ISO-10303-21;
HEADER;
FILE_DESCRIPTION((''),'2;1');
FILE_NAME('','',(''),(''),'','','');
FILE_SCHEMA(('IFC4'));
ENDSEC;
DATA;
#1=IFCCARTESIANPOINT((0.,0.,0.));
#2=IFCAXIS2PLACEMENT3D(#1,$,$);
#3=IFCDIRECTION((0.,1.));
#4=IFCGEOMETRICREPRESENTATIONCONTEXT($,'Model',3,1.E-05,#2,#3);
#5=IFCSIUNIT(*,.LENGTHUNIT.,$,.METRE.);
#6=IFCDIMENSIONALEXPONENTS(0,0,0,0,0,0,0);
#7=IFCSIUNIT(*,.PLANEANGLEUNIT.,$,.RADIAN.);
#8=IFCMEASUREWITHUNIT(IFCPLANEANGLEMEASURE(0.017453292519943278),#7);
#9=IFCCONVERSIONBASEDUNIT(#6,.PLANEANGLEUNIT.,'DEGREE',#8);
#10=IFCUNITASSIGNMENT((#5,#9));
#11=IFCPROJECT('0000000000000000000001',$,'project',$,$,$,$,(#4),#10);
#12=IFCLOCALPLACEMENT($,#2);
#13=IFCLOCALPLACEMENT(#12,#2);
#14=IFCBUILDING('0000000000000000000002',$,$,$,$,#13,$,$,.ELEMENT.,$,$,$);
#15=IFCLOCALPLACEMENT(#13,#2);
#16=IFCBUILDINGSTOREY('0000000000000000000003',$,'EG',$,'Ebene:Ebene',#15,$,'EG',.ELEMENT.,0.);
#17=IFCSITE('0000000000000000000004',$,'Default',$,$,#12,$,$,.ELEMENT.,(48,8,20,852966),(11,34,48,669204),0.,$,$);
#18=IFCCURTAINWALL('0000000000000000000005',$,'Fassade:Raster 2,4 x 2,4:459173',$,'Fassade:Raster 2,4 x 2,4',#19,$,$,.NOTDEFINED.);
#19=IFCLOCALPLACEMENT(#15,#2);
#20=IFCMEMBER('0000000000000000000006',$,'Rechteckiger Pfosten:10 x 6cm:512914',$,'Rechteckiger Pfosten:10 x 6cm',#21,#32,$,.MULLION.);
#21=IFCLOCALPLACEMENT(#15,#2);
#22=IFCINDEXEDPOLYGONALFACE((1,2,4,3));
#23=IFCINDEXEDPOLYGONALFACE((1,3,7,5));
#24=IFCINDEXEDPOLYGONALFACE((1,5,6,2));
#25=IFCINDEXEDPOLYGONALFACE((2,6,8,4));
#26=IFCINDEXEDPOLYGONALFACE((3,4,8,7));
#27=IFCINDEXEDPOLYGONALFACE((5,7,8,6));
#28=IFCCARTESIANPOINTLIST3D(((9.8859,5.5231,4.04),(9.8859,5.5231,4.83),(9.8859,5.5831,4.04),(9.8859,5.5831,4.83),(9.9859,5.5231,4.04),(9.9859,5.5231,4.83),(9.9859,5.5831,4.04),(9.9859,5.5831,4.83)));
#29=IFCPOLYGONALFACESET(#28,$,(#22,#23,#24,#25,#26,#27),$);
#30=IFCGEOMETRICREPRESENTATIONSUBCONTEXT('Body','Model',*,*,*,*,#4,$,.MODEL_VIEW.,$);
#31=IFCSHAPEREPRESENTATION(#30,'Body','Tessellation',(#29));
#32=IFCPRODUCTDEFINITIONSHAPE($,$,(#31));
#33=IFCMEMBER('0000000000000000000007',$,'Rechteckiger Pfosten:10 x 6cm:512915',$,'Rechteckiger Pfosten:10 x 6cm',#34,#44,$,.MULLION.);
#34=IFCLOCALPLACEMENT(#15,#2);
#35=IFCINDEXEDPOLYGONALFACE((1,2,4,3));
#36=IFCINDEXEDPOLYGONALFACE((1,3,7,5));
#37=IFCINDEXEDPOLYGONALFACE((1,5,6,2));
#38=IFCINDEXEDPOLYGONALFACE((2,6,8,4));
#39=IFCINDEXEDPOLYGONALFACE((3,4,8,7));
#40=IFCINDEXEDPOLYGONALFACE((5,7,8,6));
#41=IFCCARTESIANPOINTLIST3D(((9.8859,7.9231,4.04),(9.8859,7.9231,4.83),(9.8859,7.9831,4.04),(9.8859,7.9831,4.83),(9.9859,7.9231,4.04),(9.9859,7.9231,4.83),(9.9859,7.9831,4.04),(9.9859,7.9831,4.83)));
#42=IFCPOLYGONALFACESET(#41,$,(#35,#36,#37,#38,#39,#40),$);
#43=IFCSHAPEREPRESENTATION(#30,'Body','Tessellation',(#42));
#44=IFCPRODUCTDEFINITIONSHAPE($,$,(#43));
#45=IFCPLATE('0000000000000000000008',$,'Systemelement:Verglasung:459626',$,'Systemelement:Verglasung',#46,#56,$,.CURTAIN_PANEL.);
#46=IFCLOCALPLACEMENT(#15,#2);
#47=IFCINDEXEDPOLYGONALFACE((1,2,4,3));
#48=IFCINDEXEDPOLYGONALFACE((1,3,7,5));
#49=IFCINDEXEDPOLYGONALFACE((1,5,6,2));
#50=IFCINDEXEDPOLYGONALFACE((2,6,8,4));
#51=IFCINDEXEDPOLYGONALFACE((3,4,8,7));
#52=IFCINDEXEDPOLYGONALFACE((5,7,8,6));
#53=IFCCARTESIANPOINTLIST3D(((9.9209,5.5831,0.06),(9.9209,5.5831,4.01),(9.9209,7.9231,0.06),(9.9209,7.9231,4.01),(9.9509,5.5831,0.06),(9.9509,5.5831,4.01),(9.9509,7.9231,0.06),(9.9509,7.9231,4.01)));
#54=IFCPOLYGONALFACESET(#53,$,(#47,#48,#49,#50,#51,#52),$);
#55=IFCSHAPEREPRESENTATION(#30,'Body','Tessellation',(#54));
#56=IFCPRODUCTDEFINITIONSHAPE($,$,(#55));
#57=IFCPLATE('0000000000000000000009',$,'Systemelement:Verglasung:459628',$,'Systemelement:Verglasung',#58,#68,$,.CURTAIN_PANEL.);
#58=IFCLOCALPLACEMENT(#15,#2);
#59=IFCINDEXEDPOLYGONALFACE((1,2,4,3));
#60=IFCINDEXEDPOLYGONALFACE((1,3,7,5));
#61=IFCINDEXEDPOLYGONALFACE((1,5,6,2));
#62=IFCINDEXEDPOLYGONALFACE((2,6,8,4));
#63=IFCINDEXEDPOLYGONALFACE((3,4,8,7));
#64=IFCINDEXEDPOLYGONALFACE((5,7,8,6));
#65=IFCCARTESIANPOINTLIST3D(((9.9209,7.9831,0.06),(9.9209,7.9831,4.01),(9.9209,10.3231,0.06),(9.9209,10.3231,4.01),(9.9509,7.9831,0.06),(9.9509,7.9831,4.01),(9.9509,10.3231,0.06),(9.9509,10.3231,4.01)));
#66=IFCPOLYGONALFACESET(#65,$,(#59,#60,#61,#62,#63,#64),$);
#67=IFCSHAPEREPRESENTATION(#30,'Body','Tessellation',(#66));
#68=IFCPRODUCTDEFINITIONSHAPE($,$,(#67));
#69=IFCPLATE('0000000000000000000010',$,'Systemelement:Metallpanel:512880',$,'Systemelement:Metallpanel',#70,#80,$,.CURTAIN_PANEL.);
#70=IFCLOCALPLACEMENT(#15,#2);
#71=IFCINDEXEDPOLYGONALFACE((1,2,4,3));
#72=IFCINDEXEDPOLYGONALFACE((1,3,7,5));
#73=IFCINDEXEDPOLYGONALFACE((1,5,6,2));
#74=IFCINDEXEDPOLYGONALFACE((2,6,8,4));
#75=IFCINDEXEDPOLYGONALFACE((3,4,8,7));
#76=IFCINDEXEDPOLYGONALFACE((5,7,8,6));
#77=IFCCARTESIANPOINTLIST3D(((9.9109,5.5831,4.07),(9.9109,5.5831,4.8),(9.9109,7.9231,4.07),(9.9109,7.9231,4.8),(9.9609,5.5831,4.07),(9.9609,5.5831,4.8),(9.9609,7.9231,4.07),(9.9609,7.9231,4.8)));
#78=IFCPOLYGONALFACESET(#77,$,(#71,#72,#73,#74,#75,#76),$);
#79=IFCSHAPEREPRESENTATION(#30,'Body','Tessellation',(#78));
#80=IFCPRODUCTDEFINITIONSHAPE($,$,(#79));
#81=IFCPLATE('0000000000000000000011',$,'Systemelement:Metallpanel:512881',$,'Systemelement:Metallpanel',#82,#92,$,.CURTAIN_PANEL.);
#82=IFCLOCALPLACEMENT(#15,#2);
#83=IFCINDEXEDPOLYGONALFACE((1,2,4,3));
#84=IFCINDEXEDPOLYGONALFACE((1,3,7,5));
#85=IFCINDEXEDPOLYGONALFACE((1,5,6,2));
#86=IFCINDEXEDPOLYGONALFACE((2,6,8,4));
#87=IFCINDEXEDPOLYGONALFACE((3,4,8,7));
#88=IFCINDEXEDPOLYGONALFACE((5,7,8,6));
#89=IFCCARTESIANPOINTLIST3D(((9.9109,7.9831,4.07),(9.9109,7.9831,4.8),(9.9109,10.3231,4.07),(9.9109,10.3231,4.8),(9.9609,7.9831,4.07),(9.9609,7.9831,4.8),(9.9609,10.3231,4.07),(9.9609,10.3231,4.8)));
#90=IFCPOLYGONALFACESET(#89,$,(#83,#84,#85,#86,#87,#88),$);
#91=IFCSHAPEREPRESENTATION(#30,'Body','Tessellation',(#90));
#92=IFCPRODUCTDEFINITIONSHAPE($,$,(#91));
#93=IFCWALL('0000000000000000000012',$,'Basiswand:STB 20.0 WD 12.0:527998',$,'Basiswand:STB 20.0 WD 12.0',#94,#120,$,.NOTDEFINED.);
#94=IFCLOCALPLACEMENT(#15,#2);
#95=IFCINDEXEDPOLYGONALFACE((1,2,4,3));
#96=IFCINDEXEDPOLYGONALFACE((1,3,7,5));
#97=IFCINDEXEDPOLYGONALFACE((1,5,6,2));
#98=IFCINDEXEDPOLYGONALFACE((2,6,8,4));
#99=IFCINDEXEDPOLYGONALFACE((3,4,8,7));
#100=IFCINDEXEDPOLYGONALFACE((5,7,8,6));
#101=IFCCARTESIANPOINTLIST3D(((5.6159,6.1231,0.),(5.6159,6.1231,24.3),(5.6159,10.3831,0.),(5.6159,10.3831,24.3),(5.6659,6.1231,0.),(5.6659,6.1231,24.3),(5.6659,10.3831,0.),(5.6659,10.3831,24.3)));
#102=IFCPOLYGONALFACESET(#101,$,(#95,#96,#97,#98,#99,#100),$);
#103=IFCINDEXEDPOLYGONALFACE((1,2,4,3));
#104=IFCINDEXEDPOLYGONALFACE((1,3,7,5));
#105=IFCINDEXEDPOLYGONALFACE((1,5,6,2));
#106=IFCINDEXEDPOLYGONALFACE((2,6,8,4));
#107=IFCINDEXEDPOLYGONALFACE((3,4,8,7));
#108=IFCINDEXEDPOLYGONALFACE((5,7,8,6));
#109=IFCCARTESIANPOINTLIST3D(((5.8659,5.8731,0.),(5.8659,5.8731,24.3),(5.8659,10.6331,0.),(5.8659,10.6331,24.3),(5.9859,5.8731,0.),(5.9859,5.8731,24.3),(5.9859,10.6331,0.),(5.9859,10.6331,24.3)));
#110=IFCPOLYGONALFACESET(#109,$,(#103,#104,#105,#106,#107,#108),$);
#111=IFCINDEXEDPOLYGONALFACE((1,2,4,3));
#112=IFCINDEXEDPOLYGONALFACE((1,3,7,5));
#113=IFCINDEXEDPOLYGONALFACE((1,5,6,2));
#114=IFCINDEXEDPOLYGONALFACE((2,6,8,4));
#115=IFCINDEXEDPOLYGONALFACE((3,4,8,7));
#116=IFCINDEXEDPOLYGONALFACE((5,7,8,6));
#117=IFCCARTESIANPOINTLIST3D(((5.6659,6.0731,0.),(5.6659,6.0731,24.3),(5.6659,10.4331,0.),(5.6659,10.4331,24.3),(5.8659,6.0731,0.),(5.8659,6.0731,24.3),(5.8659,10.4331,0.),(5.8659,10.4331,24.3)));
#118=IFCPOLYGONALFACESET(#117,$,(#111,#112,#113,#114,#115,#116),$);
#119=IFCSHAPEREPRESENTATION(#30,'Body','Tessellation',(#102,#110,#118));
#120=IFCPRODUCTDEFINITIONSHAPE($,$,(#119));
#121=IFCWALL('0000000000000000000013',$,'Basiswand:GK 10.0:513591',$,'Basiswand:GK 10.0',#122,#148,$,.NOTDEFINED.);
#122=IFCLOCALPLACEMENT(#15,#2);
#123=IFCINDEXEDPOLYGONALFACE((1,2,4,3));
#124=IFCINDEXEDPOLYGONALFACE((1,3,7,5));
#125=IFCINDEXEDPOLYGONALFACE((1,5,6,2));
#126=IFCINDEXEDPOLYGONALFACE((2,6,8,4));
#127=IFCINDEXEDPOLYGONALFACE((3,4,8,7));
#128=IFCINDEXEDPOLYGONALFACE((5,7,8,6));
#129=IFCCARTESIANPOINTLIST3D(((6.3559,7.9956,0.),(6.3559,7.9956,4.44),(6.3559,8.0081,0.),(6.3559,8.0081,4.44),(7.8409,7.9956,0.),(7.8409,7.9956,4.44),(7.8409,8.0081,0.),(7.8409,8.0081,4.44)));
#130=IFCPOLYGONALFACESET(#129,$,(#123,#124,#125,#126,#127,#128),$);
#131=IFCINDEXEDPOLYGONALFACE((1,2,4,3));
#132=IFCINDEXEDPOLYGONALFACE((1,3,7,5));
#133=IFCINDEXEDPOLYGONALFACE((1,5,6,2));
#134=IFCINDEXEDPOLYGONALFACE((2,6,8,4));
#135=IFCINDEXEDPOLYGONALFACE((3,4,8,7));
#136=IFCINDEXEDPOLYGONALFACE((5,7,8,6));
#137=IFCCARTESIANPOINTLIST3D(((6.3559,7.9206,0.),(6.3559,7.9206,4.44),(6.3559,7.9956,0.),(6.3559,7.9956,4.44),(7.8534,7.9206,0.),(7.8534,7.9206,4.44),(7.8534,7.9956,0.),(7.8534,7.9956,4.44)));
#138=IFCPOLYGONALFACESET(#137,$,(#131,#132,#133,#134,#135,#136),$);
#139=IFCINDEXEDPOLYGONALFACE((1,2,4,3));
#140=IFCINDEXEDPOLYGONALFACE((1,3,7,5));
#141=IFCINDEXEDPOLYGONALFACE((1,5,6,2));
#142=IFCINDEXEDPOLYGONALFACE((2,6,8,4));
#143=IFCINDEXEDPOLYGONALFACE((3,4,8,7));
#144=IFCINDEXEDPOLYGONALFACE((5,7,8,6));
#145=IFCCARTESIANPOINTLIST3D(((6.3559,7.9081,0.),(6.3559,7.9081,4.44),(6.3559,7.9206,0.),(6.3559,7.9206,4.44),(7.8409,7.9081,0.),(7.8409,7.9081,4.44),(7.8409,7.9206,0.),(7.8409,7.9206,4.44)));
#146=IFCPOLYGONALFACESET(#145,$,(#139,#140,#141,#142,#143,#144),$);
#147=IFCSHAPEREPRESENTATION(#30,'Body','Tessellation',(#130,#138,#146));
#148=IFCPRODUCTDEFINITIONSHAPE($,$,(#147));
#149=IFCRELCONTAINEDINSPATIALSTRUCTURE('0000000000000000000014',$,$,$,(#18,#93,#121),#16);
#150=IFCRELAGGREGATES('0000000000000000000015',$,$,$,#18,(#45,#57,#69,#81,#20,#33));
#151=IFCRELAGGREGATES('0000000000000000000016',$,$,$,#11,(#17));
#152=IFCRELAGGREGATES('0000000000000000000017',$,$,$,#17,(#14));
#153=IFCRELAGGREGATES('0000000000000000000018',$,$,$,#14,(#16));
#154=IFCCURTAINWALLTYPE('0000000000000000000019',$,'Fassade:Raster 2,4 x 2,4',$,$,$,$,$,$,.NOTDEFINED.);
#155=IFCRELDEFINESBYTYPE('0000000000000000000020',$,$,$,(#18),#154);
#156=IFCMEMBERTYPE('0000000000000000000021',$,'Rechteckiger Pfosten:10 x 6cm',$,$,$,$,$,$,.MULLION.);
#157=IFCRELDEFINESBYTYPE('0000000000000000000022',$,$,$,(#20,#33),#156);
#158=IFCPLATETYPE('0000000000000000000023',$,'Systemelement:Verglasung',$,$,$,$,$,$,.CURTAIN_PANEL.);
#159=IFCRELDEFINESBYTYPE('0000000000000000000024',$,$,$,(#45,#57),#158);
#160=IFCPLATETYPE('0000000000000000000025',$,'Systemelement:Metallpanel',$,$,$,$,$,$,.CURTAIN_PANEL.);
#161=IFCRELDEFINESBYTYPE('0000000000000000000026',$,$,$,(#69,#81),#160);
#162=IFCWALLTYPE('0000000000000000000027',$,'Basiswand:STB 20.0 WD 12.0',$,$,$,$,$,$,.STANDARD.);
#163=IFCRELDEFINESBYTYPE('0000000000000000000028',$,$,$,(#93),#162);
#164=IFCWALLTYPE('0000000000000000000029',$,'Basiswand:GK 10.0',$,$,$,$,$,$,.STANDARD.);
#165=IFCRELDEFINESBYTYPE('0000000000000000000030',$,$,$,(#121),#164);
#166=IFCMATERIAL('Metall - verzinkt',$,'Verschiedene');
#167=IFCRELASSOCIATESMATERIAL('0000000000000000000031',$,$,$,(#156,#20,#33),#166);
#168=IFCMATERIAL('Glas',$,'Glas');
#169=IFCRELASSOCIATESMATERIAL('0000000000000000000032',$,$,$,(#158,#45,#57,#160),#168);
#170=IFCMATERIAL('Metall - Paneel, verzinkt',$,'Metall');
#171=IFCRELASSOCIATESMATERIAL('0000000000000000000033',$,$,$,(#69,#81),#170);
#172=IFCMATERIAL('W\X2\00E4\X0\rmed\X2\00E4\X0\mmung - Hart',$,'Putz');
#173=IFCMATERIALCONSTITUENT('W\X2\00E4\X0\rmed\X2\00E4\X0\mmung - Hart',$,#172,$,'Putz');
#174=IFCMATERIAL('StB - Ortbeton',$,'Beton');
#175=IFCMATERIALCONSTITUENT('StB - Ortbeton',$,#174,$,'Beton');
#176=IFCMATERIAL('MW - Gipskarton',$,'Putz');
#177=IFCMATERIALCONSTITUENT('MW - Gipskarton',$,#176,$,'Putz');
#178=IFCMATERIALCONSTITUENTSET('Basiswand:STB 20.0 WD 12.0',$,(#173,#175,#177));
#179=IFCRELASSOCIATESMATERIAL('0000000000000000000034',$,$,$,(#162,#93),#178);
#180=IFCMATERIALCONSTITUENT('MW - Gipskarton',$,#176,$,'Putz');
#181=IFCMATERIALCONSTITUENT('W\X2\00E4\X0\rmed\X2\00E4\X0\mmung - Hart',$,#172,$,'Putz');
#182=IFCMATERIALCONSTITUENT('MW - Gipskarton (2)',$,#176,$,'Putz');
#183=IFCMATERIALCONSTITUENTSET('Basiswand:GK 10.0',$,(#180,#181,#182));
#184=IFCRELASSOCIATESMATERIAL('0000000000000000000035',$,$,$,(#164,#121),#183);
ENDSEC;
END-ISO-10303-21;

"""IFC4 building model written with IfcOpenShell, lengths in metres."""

from ifc_helpers import new_model, entity, si_unit, converted_unit, direction, frame, origin, place, context, subcontext, project, spatial, indexed_curve, outline, extrude, source, transform, mapped, material, constituent, constituent_set, type_object, type_shapes, element, aggregate, save


model = new_model("IFC4")

# Units and contexts
model_context = context("Model", 3, precision=1e-05, world=origin(), true_north=direction((0.0, 1.0)))
body_context = subcontext(model_context, "Body", "Model", "MODEL_VIEW")
ifc_project = project(units=[si_unit("LENGTHUNIT", "METRE"), converted_unit("PLANEANGLEUNIT", "DEGREE", entity("IfcPlaneAngleMeasure", 0.017453292519943278), si_unit("PLANEANGLEUNIT", "RADIAN"), dimensions=[0, 0, 0, 0, 0, 0, 0])], contexts=[model_context])

# Site, building, storey
site_placement = place(None, origin())
site = spatial("IfcSite", under=ifc_project, at=site_placement, Name="Default", CompositionType="ELEMENT", RefLatitude=(48, 8, 20, 852966), RefLongitude=(11, 34, 48, 669204), RefElevation=0.0)
building_placement = place(site_placement, origin())
building = spatial("IfcBuilding", under=site, at=building_placement, CompositionType="ELEMENT")
storey_placement = place(building_placement, origin())
storey = spatial("IfcBuildingStorey", under=building, at=storey_placement, Name="EG", ObjectType="Ebene:Ebene", LongName="EG", CompositionType="ELEMENT", Elevation=0.0)

# Curtain wall, members, plates
curtain_wall_type = type_object("IfcCurtainWallType", Name="Fassade:Raster 2,4 x 2,4", PredefinedType="NOTDEFINED")
curtain_wall_placement = place(storey_placement, origin())
curtain_wall = element("IfcCurtainWall", 1, at=curtain_wall_placement, inside=storey, type_object=curtain_wall_type, Name="Fassade:Raster 2,4 x 2,4:459173", ObjectType="Fassade:Raster 2,4 x 2,4", PredefinedType="NOTDEFINED")
ifc_material_1 = material(Name="Metall - verzinkt", Category="Verschiedene")
member_type_1 = type_object("IfcMemberType", Name="Rechteckiger Pfosten:10 x 6cm", PredefinedType="MULLION", material=ifc_material_1)
shared_shape_1 = source(origin(), body_context, "Body", "SweptSolid", [
    extrude(outline(indexed_curve([(-0.03, -0.05), (0.03, -0.05), (0.03, 0.05), (-0.03, 0.05), (-0.03, -0.05)], self_intersect=False)), frame((0.0, 0.0, -0.79), z_axis=(0.0, 0.0, 1.0), x_axis=(-1.0, 0.0, 0.0)), (0.0, 0.0, 1.0), 0.79),
])
type_shapes(member_type_1, [shared_shape_1])
member_1_placement = place(curtain_wall_placement, frame((9.9359, 5.5531, 4.04), z_axis=(0.0, 0.0, -1.0), x_axis=(0.0, 1.0, 0.0)))
member_1 = element("IfcMember", 2, at=member_1_placement, type_object=member_type_1, material=ifc_material_1, Name="Rechteckiger Pfosten:10 x 6cm:512914", ObjectType="Rechteckiger Pfosten:10 x 6cm", PredefinedType="MULLION", context=body_context, shape_type="MappedRepresentation", body=[
    mapped(shared_shape_1, transform((0.0, 0.0, 0.0), scale=1.0)),
])
member_2_placement = place(curtain_wall_placement, frame((9.9359, 7.9531, 4.04), z_axis=(0.0, 0.0, -1.0), x_axis=(0.0, 1.0, 0.0)))
member_2 = element("IfcMember", 3, at=member_2_placement, type_object=member_type_1, material=ifc_material_1, Name="Rechteckiger Pfosten:10 x 6cm:512915", ObjectType="Rechteckiger Pfosten:10 x 6cm", PredefinedType="MULLION", context=body_context, shape_type="MappedRepresentation", body=[
    mapped(shared_shape_1, transform((0.0, 0.0, 0.0), scale=1.0)),
])
ifc_material_2 = material(Name="Glas", Category="Glas")
plate_type_1 = type_object("IfcPlateType", Name="Systemelement:Verglasung", PredefinedType="CURTAIN_PANEL", material=ifc_material_2)
shared_shape_2 = source(origin(), body_context, "Body", "SweptSolid", [
    extrude(outline(indexed_curve([(-0.015, -1.17), (0.015, -1.17), (0.015, 1.17), (-0.015, 1.17), (-0.015, -1.17)], self_intersect=False)), frame((0.0, 0.0, 0.0), z_axis=(0.0, 0.0, 1.0), x_axis=(0.0, 1.0, 0.0)), (0.0, 0.0, 1.0), 3.95),
])
type_shapes(plate_type_1, [shared_shape_2])
plate_1_placement = place(curtain_wall_placement, frame((9.9359, 6.7531, 0.06), z_axis=(0.0, 0.0, 1.0), x_axis=(0.0, 1.0, 0.0)))
plate_1 = element("IfcPlate", 4, at=plate_1_placement, type_object=plate_type_1, material=ifc_material_2, Name="Systemelement:Verglasung:459626", ObjectType="Systemelement:Verglasung", PredefinedType="CURTAIN_PANEL", context=body_context, shape_type="MappedRepresentation", body=[
    mapped(shared_shape_2, transform((0.0, 0.0, 0.0), scale=1.0)),
])
plate_2_placement = place(curtain_wall_placement, frame((9.9359, 9.1531, 0.06), z_axis=(0.0, 0.0, 1.0), x_axis=(0.0, 1.0, 0.0)))
plate_2 = element("IfcPlate", 5, at=plate_2_placement, type_object=plate_type_1, material=ifc_material_2, Name="Systemelement:Verglasung:459628", ObjectType="Systemelement:Verglasung", PredefinedType="CURTAIN_PANEL", context=body_context, shape_type="MappedRepresentation", body=[
    mapped(shared_shape_2, transform((0.0, 0.0, 0.0), scale=1.0)),
])
ifc_material_3 = material(Name="Metall - Paneel, verzinkt", Category="Metall")
plate_type_2 = type_object("IfcPlateType", Name="Systemelement:Metallpanel", PredefinedType="CURTAIN_PANEL", material=ifc_material_2)
shared_shape_3 = source(origin(), body_context, "Body", "SweptSolid", [
    extrude(outline(indexed_curve([(-0.025, -1.17), (0.025, -1.17), (0.025, 1.17), (-0.025, 1.17), (-0.025, -1.17)], self_intersect=False)), frame((0.0, 0.0, 0.0), z_axis=(0.0, 0.0, 1.0), x_axis=(0.0, 1.0, 0.0)), (0.0, 0.0, 1.0), 0.73),
])
type_shapes(plate_type_2, [shared_shape_3])
plate_3_placement = place(curtain_wall_placement, frame((9.9359, 6.7531, 4.07), z_axis=(0.0, 0.0, 1.0), x_axis=(0.0, 1.0, 0.0)))
plate_3 = element("IfcPlate", 6, at=plate_3_placement, type_object=plate_type_2, material=ifc_material_3, Name="Systemelement:Metallpanel:512880", ObjectType="Systemelement:Metallpanel", PredefinedType="CURTAIN_PANEL", context=body_context, shape_type="MappedRepresentation", body=[
    mapped(shared_shape_3, transform((0.0, 0.0, 0.0), scale=1.0)),
])
plate_4_placement = place(curtain_wall_placement, frame((9.9359, 9.1531, 4.07), z_axis=(0.0, 0.0, 1.0), x_axis=(0.0, 1.0, 0.0)))
plate_4 = element("IfcPlate", 7, at=plate_4_placement, type_object=plate_type_2, material=ifc_material_3, Name="Systemelement:Metallpanel:512881", ObjectType="Systemelement:Metallpanel", PredefinedType="CURTAIN_PANEL", context=body_context, shape_type="MappedRepresentation", body=[
    mapped(shared_shape_3, transform((0.0, 0.0, 0.0), scale=1.0)),
])
aggregate(curtain_wall, [plate_1, plate_2, plate_3, plate_4, member_1, member_2])

# Wall
ifc_material_4 = material(Name="Wärmedämmung - Hart", Category="Putz")
ifc_material_5 = material(Name="StB - Ortbeton", Category="Beton")
ifc_constituent_1 = constituent(ifc_material_4, Name="Wärmedämmung - Hart", Category="Putz")
ifc_constituent_2 = constituent(ifc_material_5, Name="StB - Ortbeton", Category="Beton")
ifc_material_6 = material(Name="MW - Gipskarton", Category="Putz")
ifc_constituent_3 = constituent(ifc_material_6, Name="MW - Gipskarton", Category="Putz")
ifc_constituent_set_1 = constituent_set(constituents=[ifc_constituent_1, ifc_constituent_2, ifc_constituent_3], Name="Basiswand:STB 20.0 WD 12.0")
wall_type_1 = type_object("IfcWallType", Name="Basiswand:STB 20.0 WD 12.0", PredefinedType="STANDARD", material=ifc_constituent_set_1)
wall_1_placement = place(storey_placement, frame((5.8009, 6.1231, 0.0), z_axis=(0.0, 0.0, 1.0), x_axis=(0.0, 1.0, 0.0)))
element("IfcWall", 8, at=wall_1_placement, inside=storey, type_object=wall_type_1, material=ifc_constituent_set_1, Name="Basiswand:STB 20.0 WD 12.0:527998", ObjectType="Basiswand:STB 20.0 WD 12.0", PredefinedType="NOTDEFINED", context=body_context, shape_type="SweptSolid", body=[
    extrude(outline(indexed_curve([(-0.025, -2.13), (0.025, -2.13), (0.025, 2.13), (-0.025, 2.13), (-0.025, -2.13)], self_intersect=False)), frame((2.13, 0.16, 0.0), z_axis=(0.0, 0.0, 1.0), x_axis=(0.0, -1.0, 0.0)), (0.0, 0.0, 1.0), 24.3),
    extrude(outline(indexed_curve([(-0.06, -2.38), (0.06, -2.38), (0.06, 2.38), (-0.06, 2.38), (-0.06, -2.38)], self_intersect=False)), frame((2.13, -0.125, 0.0), z_axis=(0.0, 0.0, 1.0), x_axis=(0.0, 1.0, 0.0)), (0.0, 0.0, 1.0), 24.3),
    extrude(outline(indexed_curve([(-2.18, -0.1), (2.18, -0.1), (2.18, 0.1), (-2.18, 0.1), (-2.18, -0.1)], self_intersect=False)), frame((2.13, 0.035, 0.0)), (0.0, 0.0, 1.0), 24.3),
])

# Shared definitions
ifc_constituent_4 = constituent(ifc_material_6, Name="MW - Gipskarton", Category="Putz")
ifc_constituent_5 = constituent(ifc_material_4, Name="Wärmedämmung - Hart", Category="Putz")
ifc_constituent_6 = constituent(ifc_material_6, Name="MW - Gipskarton (2)", Category="Putz")
ifc_constituent_set_2 = constituent_set(constituents=[ifc_constituent_4, ifc_constituent_5, ifc_constituent_6], Name="Basiswand:GK 10.0")
wall_type_2 = type_object("IfcWallType", Name="Basiswand:GK 10.0", PredefinedType="STANDARD", material=ifc_constituent_set_2)

# Wall
wall_2_placement = place(storey_placement, frame((7.8409, 7.9581, 0.0), z_axis=(0.0, 0.0, 1.0), x_axis=(-1.0, 0.0, 0.0)))
element("IfcWall", 9, at=wall_2_placement, inside=storey, type_object=wall_type_2, material=ifc_constituent_set_2, Name="Basiswand:GK 10.0:513591", ObjectType="Basiswand:GK 10.0", PredefinedType="NOTDEFINED", context=body_context, shape_type="SweptSolid", body=[
    extrude(outline(indexed_curve([(-0.0063, -0.7425), (0.0062, -0.7425), (0.0063, 0.7425), (-0.0062, 0.7425), (-0.0063, -0.7425)], self_intersect=False)), frame((0.7425, -0.0437, 0.0), z_axis=(0.0, 0.0, 1.0), x_axis=(0.0, 1.0, 0.0)), (0.0, 0.0, 1.0), 4.44),
    extrude(outline(indexed_curve([(-0.7488, -0.0375), (0.7488, -0.0375), (0.7488, 0.0375), (-0.7488, 0.0375), (-0.7488, -0.0375)], self_intersect=False)), frame((0.7363, 0.0, 0.0)), (0.0, 0.0, 1.0), 4.44),
    extrude(outline(indexed_curve([(-0.0063, -0.7425), (0.0062, -0.7425), (0.0063, 0.7425), (-0.0062, 0.7425), (-0.0063, -0.7425)], self_intersect=False)), frame((0.7425, 0.0437, 0.0), z_axis=(0.0, 0.0, 1.0), x_axis=(0.0, -1.0, 0.0)), (0.0, 0.0, 1.0), 4.44),
])

save(model, "model.ifc")
